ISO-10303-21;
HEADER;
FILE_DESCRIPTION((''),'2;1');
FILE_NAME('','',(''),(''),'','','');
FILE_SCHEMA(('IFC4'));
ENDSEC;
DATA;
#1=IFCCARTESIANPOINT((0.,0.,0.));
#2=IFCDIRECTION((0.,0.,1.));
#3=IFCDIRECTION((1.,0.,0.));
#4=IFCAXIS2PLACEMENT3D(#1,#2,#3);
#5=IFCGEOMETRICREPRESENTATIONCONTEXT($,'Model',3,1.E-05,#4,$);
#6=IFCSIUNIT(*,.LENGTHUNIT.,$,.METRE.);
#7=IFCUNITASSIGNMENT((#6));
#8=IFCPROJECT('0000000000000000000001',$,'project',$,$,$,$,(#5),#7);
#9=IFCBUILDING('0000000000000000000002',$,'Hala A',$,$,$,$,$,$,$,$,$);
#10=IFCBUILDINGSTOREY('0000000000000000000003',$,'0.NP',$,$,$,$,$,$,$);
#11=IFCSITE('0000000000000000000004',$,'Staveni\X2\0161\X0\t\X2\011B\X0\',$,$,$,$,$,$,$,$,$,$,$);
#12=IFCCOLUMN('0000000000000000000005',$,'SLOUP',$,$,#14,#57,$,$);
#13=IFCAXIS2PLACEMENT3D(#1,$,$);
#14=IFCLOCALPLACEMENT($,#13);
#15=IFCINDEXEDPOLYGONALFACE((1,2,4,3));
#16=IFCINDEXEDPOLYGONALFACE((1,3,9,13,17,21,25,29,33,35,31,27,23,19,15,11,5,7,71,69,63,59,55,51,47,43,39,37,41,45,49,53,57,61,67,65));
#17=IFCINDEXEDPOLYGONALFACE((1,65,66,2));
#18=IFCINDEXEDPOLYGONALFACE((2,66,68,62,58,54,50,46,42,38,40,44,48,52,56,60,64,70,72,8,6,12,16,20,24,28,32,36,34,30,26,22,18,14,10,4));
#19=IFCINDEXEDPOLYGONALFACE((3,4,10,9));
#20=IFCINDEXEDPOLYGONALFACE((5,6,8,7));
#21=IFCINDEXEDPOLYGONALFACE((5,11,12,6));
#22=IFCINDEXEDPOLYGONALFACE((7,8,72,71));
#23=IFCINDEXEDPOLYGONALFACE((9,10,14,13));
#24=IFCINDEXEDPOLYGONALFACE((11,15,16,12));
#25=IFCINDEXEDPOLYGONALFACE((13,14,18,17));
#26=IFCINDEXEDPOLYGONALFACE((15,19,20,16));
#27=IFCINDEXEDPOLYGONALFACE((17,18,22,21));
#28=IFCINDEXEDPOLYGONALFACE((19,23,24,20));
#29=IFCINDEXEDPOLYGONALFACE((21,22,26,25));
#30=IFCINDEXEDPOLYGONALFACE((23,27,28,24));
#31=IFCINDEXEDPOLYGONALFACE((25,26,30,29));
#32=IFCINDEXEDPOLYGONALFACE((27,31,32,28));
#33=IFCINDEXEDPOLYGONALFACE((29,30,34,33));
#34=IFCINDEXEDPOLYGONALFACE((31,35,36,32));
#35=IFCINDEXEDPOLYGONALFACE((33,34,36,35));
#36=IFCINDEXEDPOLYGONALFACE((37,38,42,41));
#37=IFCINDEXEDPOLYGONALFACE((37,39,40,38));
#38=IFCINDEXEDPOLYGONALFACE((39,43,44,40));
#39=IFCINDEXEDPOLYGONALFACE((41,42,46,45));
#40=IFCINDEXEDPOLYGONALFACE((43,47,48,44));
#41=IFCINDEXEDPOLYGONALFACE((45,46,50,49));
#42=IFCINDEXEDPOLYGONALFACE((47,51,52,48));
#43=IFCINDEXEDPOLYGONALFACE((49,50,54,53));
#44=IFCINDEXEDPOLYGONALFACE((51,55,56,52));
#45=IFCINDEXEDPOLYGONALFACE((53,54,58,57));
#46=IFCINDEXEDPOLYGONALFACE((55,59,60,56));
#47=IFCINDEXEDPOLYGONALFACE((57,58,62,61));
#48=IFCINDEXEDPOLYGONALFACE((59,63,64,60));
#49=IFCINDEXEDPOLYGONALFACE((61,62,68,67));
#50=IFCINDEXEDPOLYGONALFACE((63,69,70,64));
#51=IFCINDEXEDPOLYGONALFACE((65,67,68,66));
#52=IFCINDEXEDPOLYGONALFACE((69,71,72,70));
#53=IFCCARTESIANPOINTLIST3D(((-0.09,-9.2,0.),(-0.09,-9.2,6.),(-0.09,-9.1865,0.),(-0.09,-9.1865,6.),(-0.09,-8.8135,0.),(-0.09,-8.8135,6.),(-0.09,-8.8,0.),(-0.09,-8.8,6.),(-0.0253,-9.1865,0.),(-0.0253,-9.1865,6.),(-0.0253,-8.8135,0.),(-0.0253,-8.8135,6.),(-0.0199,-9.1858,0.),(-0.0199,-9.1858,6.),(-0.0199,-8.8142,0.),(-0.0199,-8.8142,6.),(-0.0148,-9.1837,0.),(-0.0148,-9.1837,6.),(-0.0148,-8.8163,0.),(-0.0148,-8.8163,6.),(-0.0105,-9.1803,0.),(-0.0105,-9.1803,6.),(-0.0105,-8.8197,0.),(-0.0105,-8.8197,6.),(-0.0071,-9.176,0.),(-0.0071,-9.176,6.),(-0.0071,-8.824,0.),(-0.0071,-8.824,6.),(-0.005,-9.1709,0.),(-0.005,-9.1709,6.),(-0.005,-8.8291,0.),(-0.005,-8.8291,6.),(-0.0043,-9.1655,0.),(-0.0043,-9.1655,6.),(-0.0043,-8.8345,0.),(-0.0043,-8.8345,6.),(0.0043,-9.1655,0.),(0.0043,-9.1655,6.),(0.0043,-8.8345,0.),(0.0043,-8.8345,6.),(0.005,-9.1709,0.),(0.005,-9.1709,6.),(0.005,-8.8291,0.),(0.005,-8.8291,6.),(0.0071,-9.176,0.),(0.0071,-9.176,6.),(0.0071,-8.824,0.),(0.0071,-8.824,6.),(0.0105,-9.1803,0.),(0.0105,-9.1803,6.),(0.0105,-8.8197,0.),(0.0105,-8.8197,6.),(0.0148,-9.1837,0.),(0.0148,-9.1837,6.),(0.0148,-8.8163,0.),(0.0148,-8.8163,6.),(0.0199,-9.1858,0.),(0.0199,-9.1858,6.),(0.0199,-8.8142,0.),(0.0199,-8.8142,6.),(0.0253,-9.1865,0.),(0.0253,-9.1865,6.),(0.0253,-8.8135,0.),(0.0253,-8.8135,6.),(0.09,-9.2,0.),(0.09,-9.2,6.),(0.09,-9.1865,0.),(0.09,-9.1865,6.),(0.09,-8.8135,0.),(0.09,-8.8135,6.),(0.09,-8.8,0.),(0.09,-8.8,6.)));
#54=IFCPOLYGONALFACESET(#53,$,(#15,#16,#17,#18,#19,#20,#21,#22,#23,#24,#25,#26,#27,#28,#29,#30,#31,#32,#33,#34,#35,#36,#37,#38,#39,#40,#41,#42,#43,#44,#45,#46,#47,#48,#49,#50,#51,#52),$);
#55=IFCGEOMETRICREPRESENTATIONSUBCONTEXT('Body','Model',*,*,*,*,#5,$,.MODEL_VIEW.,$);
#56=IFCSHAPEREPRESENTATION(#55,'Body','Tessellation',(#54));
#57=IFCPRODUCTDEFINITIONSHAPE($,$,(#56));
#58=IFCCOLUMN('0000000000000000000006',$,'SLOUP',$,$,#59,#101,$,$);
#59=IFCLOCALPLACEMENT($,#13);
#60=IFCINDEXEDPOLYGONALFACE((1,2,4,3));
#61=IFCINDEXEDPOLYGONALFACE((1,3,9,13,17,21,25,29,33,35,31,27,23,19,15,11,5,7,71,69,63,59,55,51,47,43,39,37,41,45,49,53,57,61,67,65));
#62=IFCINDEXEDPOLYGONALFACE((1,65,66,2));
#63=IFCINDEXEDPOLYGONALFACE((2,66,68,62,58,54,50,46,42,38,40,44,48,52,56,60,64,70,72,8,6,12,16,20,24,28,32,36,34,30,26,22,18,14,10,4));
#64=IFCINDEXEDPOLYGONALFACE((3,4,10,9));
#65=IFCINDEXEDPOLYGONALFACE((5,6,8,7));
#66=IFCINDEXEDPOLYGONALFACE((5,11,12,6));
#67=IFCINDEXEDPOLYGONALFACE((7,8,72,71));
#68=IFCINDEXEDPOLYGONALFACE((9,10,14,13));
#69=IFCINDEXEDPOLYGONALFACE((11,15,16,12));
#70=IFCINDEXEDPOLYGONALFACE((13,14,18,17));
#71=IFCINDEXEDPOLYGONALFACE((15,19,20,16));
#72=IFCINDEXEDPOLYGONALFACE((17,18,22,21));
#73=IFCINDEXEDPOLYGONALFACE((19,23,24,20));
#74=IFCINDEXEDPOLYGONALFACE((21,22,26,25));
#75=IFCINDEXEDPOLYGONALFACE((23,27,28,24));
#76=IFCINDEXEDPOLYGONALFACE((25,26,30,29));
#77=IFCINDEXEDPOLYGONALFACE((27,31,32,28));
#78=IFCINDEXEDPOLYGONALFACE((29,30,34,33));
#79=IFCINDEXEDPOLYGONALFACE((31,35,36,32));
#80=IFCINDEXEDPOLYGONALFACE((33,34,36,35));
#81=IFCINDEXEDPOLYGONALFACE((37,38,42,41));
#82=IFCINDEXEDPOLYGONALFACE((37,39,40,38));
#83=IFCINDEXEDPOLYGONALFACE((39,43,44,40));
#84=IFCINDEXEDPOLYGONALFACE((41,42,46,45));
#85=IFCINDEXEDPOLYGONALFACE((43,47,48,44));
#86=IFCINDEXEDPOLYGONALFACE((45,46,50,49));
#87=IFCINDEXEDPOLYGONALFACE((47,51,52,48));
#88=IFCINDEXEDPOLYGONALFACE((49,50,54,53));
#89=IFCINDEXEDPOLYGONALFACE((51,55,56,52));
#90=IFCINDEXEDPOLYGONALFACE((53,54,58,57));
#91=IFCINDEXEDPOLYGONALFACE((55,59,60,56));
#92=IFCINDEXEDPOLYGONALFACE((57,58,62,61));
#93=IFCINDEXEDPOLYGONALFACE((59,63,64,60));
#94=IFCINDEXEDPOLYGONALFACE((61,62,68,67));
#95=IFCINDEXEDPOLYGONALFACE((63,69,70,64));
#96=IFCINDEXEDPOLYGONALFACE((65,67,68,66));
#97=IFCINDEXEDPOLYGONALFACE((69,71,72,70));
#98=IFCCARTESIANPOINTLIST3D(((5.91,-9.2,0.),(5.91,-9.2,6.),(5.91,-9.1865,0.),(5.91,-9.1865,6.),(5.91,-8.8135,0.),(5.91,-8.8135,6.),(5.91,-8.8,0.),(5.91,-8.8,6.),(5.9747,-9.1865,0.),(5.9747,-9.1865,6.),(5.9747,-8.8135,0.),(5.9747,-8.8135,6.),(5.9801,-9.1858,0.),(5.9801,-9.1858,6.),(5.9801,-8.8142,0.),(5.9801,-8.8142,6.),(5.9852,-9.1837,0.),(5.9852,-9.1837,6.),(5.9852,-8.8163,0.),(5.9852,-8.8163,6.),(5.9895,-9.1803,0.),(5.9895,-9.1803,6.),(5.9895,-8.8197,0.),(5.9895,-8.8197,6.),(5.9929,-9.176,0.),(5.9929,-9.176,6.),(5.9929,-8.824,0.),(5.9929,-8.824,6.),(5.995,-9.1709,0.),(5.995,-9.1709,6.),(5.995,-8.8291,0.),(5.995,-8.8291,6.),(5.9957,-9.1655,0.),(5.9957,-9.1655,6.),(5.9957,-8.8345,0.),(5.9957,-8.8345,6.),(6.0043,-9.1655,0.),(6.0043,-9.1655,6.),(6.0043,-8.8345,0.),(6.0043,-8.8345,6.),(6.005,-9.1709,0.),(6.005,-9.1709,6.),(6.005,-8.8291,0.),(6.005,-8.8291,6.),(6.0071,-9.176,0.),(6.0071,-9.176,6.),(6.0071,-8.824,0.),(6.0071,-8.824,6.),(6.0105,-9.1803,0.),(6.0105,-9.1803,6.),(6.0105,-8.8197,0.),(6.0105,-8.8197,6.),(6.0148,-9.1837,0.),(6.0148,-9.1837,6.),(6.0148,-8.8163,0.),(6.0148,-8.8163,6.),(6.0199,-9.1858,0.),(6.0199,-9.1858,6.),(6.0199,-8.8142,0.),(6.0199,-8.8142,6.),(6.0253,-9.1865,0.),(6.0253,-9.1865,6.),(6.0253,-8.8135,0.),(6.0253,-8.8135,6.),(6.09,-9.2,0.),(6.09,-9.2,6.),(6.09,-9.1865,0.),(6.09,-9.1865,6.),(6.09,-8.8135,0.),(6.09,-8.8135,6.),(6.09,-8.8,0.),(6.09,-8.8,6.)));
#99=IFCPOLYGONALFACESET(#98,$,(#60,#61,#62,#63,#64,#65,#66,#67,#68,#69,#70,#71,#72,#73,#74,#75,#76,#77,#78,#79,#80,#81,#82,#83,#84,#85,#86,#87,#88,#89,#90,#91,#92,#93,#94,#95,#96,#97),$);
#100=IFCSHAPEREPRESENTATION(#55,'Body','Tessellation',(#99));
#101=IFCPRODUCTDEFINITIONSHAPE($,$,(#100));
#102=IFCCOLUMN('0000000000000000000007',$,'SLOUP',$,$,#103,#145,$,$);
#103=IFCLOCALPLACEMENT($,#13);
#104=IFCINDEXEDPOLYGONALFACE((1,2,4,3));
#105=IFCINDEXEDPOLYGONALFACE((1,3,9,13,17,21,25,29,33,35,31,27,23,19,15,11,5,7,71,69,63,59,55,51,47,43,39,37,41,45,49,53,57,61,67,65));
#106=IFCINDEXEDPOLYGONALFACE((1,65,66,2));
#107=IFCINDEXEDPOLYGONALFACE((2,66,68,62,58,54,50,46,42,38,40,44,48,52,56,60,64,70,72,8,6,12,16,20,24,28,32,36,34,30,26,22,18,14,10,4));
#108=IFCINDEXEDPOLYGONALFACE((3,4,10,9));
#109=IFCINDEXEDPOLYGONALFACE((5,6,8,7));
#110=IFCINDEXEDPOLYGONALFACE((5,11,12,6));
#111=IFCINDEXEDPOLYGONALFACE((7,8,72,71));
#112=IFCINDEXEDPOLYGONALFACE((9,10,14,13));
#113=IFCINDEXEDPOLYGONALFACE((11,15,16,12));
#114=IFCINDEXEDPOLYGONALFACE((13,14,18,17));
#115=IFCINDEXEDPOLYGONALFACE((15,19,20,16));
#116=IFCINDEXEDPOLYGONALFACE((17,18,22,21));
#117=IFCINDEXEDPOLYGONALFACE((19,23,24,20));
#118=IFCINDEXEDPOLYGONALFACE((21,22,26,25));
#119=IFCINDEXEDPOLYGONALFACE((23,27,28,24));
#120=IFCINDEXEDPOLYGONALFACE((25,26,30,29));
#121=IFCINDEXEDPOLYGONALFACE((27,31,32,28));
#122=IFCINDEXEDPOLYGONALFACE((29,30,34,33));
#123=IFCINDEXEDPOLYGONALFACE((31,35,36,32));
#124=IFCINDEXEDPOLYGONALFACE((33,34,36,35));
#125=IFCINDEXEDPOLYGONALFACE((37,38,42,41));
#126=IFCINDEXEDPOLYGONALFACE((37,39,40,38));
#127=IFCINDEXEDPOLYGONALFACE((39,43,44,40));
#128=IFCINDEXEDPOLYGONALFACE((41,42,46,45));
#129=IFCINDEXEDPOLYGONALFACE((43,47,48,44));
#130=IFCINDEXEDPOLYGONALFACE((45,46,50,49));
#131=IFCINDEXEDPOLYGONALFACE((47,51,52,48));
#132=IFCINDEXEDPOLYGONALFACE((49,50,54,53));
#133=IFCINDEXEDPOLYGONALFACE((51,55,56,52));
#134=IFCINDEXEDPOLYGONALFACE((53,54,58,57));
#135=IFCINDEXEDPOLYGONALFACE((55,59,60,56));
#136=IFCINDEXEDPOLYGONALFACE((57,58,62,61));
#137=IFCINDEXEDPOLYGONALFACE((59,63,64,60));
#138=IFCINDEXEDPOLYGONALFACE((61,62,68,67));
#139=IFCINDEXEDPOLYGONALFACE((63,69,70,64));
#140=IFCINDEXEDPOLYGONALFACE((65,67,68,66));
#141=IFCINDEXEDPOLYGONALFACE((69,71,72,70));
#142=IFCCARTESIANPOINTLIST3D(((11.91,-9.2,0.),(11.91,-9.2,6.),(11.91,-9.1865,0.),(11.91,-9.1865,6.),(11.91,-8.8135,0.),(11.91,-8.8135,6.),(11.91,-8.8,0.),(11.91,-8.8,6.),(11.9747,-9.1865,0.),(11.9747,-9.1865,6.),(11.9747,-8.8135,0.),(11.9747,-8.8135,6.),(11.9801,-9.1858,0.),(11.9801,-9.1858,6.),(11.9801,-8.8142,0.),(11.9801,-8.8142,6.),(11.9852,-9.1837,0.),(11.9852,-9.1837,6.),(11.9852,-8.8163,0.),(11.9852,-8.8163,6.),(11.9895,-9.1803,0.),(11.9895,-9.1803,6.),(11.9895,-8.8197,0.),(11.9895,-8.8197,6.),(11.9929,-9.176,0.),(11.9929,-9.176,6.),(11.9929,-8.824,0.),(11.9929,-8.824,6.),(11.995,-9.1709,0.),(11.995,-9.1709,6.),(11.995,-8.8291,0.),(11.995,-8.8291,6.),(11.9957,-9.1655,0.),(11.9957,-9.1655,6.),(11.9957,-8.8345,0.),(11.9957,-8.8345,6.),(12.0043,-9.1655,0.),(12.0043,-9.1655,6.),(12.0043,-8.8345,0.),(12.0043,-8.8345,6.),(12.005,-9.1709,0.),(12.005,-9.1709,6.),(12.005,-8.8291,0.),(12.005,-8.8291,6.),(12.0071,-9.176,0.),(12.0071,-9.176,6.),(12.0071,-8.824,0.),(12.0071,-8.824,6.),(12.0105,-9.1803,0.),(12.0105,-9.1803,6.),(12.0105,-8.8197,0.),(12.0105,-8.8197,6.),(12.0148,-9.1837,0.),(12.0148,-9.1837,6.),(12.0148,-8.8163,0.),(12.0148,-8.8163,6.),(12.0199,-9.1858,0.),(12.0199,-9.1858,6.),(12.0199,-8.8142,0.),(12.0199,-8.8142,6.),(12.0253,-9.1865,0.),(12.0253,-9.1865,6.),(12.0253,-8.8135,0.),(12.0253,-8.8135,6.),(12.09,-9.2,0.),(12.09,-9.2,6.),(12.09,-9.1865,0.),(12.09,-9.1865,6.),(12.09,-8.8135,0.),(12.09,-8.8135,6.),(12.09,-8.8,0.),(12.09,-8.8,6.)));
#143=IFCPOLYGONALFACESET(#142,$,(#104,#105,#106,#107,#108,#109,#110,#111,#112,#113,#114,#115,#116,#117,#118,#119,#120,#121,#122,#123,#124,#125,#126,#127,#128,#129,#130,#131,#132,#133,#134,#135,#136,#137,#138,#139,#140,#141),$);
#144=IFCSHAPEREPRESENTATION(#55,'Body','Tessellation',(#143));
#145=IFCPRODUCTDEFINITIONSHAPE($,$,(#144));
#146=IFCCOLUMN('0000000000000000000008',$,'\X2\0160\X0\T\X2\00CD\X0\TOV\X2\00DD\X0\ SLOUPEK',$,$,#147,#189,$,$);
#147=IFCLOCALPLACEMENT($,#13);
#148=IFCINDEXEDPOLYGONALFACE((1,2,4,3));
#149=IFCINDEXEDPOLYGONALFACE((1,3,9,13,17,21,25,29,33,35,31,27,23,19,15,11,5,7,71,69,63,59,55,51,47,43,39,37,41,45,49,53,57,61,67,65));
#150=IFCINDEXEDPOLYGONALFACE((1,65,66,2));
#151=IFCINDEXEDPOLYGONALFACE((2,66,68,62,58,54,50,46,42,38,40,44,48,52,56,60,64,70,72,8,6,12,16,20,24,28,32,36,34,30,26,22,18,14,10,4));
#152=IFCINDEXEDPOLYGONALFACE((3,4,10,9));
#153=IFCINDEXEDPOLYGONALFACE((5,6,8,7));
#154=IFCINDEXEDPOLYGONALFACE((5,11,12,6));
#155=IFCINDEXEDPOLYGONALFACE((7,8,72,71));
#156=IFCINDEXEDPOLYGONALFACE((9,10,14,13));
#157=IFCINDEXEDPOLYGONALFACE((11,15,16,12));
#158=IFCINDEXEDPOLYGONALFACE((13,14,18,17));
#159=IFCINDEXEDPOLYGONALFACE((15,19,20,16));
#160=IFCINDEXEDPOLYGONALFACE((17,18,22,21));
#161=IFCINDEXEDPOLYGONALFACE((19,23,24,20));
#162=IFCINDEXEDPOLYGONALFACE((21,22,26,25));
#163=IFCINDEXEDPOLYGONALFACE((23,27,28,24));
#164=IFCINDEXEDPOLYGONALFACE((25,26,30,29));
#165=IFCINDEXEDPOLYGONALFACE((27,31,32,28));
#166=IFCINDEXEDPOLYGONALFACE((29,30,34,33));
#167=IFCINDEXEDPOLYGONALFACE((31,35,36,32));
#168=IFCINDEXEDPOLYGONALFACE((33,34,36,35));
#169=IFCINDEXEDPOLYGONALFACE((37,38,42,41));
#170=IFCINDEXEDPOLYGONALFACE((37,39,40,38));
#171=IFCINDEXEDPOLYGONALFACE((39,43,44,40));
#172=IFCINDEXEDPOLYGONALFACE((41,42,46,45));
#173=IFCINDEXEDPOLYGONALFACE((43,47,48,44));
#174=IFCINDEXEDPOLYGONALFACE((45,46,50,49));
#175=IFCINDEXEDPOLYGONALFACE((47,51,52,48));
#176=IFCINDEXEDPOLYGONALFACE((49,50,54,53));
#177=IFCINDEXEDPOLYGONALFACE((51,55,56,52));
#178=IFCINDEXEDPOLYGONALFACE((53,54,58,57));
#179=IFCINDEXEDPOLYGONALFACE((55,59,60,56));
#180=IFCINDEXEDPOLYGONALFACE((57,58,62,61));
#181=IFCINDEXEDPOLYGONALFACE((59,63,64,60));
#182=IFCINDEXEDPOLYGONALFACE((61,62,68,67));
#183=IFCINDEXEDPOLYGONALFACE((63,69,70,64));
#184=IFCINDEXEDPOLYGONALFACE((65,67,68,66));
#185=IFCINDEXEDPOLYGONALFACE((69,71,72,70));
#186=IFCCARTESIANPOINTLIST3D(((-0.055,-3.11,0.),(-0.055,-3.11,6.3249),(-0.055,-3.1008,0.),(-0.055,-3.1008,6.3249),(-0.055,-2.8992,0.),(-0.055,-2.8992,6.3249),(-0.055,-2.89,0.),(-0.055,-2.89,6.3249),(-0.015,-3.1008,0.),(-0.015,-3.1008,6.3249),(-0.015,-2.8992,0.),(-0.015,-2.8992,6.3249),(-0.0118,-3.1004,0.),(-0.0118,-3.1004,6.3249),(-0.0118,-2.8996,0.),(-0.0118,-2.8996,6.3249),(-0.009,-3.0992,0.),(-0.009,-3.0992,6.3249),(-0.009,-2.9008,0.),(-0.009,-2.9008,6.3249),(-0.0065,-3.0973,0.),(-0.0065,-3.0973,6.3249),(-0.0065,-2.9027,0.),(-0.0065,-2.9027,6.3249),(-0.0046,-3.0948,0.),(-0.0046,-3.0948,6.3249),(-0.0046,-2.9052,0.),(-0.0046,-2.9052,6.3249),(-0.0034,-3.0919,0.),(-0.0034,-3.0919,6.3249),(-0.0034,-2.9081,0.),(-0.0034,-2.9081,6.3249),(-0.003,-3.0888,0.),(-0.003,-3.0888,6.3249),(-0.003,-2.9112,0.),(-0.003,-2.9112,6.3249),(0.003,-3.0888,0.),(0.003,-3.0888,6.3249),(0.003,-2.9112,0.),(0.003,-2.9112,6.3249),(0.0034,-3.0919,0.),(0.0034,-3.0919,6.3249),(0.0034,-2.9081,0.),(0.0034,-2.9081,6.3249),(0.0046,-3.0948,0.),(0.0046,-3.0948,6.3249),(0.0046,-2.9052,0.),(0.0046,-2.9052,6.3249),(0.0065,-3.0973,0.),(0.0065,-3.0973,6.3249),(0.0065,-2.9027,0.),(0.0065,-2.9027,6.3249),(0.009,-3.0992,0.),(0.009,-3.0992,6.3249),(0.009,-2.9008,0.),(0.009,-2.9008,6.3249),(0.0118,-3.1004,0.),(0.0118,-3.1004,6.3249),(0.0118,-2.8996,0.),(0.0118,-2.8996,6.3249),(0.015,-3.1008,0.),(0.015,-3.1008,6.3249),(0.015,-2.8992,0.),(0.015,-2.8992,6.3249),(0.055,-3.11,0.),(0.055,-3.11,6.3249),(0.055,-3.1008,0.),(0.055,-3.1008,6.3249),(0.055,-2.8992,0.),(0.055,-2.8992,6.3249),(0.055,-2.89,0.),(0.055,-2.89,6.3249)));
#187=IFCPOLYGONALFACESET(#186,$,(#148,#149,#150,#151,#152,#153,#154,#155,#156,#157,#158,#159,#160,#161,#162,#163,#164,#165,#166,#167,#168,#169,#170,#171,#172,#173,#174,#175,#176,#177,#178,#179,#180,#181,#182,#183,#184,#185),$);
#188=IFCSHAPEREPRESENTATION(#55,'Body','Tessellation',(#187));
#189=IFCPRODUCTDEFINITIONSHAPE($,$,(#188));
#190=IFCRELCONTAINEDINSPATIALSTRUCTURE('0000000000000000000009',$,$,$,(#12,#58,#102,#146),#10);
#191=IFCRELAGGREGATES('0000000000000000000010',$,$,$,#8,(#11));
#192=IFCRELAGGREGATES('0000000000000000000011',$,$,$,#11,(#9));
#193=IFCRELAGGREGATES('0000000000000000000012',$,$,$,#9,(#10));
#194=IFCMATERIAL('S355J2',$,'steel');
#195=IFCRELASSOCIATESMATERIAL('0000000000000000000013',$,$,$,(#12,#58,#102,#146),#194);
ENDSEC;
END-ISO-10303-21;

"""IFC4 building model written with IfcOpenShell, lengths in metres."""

from ifc_helpers import new_model, si_unit, frame, origin_with_axes, place, context, subcontext, project, spatial, i_section, extrude, material, element, save


model = new_model("IFC4")

# Units and contexts
model_context = context("Model", 3, precision=1e-05, world=origin_with_axes())
body_context = subcontext(model_context, "Body", "Model", "MODEL_VIEW")
ifc_project = project(units=[si_unit("LENGTHUNIT", "METRE")], contexts=[model_context])

# Site, building, storey
site = spatial("IfcSite", under=ifc_project, Name="Staveniště")
building = spatial("IfcBuilding", under=site, Name="Hala A")
storey = spatial("IfcBuildingStorey", under=building, Name="0.NP")

# Columns
ifc_material = material(Name="S355J2", Category="steel")
for number, where, z_axis, x_axis, name in (
    (1, (0.0, -9.0, 0.0), (0.0, 0.0, 1.0), (1.0, 0.0, 0.0), "SLOUP"),
    (2, (6.0, -9.0, 0.0), (0.0, 0.0, 1.0), (1.0, 0.0, 0.0), "SLOUP"),
    (3, (12.0, -9.0, 0.0), (0.0, 0.0, 1.0), (1.0, 0.0, 0.0), "SLOUP"),
):
    element("IfcColumn", number, at=place(None, frame(where, z_axis=z_axis, x_axis=x_axis)), inside=storey, material=ifc_material, Name=name, context=body_context, shape_type="SweptSolid", body=[
        extrude(i_section(OverallWidth=0.18, OverallDepth=0.4, WebThickness=0.0086, FlangeThickness=0.0135, FilletRadius=0.021), origin_with_axes(), (0.0, 0.0, 1.0), 6.0),
    ])
column_placement = place(None, frame((0.0, -3.0, 0.0), z_axis=(0.0, 0.0, 1.0), x_axis=(1.0, 0.0, 0.0)))
element("IfcColumn", 4, at=column_placement, inside=storey, material=ifc_material, Name="ŠTÍTOVÝ SLOUPEK", context=body_context, shape_type="SweptSolid", body=[
    extrude(i_section(OverallWidth=0.11, OverallDepth=0.22, WebThickness=0.0059, FlangeThickness=0.0092, FilletRadius=0.012), origin_with_axes(), (0.0, 0.0, 1.0), 6.3249),
])

save(model, "model.ifc")
